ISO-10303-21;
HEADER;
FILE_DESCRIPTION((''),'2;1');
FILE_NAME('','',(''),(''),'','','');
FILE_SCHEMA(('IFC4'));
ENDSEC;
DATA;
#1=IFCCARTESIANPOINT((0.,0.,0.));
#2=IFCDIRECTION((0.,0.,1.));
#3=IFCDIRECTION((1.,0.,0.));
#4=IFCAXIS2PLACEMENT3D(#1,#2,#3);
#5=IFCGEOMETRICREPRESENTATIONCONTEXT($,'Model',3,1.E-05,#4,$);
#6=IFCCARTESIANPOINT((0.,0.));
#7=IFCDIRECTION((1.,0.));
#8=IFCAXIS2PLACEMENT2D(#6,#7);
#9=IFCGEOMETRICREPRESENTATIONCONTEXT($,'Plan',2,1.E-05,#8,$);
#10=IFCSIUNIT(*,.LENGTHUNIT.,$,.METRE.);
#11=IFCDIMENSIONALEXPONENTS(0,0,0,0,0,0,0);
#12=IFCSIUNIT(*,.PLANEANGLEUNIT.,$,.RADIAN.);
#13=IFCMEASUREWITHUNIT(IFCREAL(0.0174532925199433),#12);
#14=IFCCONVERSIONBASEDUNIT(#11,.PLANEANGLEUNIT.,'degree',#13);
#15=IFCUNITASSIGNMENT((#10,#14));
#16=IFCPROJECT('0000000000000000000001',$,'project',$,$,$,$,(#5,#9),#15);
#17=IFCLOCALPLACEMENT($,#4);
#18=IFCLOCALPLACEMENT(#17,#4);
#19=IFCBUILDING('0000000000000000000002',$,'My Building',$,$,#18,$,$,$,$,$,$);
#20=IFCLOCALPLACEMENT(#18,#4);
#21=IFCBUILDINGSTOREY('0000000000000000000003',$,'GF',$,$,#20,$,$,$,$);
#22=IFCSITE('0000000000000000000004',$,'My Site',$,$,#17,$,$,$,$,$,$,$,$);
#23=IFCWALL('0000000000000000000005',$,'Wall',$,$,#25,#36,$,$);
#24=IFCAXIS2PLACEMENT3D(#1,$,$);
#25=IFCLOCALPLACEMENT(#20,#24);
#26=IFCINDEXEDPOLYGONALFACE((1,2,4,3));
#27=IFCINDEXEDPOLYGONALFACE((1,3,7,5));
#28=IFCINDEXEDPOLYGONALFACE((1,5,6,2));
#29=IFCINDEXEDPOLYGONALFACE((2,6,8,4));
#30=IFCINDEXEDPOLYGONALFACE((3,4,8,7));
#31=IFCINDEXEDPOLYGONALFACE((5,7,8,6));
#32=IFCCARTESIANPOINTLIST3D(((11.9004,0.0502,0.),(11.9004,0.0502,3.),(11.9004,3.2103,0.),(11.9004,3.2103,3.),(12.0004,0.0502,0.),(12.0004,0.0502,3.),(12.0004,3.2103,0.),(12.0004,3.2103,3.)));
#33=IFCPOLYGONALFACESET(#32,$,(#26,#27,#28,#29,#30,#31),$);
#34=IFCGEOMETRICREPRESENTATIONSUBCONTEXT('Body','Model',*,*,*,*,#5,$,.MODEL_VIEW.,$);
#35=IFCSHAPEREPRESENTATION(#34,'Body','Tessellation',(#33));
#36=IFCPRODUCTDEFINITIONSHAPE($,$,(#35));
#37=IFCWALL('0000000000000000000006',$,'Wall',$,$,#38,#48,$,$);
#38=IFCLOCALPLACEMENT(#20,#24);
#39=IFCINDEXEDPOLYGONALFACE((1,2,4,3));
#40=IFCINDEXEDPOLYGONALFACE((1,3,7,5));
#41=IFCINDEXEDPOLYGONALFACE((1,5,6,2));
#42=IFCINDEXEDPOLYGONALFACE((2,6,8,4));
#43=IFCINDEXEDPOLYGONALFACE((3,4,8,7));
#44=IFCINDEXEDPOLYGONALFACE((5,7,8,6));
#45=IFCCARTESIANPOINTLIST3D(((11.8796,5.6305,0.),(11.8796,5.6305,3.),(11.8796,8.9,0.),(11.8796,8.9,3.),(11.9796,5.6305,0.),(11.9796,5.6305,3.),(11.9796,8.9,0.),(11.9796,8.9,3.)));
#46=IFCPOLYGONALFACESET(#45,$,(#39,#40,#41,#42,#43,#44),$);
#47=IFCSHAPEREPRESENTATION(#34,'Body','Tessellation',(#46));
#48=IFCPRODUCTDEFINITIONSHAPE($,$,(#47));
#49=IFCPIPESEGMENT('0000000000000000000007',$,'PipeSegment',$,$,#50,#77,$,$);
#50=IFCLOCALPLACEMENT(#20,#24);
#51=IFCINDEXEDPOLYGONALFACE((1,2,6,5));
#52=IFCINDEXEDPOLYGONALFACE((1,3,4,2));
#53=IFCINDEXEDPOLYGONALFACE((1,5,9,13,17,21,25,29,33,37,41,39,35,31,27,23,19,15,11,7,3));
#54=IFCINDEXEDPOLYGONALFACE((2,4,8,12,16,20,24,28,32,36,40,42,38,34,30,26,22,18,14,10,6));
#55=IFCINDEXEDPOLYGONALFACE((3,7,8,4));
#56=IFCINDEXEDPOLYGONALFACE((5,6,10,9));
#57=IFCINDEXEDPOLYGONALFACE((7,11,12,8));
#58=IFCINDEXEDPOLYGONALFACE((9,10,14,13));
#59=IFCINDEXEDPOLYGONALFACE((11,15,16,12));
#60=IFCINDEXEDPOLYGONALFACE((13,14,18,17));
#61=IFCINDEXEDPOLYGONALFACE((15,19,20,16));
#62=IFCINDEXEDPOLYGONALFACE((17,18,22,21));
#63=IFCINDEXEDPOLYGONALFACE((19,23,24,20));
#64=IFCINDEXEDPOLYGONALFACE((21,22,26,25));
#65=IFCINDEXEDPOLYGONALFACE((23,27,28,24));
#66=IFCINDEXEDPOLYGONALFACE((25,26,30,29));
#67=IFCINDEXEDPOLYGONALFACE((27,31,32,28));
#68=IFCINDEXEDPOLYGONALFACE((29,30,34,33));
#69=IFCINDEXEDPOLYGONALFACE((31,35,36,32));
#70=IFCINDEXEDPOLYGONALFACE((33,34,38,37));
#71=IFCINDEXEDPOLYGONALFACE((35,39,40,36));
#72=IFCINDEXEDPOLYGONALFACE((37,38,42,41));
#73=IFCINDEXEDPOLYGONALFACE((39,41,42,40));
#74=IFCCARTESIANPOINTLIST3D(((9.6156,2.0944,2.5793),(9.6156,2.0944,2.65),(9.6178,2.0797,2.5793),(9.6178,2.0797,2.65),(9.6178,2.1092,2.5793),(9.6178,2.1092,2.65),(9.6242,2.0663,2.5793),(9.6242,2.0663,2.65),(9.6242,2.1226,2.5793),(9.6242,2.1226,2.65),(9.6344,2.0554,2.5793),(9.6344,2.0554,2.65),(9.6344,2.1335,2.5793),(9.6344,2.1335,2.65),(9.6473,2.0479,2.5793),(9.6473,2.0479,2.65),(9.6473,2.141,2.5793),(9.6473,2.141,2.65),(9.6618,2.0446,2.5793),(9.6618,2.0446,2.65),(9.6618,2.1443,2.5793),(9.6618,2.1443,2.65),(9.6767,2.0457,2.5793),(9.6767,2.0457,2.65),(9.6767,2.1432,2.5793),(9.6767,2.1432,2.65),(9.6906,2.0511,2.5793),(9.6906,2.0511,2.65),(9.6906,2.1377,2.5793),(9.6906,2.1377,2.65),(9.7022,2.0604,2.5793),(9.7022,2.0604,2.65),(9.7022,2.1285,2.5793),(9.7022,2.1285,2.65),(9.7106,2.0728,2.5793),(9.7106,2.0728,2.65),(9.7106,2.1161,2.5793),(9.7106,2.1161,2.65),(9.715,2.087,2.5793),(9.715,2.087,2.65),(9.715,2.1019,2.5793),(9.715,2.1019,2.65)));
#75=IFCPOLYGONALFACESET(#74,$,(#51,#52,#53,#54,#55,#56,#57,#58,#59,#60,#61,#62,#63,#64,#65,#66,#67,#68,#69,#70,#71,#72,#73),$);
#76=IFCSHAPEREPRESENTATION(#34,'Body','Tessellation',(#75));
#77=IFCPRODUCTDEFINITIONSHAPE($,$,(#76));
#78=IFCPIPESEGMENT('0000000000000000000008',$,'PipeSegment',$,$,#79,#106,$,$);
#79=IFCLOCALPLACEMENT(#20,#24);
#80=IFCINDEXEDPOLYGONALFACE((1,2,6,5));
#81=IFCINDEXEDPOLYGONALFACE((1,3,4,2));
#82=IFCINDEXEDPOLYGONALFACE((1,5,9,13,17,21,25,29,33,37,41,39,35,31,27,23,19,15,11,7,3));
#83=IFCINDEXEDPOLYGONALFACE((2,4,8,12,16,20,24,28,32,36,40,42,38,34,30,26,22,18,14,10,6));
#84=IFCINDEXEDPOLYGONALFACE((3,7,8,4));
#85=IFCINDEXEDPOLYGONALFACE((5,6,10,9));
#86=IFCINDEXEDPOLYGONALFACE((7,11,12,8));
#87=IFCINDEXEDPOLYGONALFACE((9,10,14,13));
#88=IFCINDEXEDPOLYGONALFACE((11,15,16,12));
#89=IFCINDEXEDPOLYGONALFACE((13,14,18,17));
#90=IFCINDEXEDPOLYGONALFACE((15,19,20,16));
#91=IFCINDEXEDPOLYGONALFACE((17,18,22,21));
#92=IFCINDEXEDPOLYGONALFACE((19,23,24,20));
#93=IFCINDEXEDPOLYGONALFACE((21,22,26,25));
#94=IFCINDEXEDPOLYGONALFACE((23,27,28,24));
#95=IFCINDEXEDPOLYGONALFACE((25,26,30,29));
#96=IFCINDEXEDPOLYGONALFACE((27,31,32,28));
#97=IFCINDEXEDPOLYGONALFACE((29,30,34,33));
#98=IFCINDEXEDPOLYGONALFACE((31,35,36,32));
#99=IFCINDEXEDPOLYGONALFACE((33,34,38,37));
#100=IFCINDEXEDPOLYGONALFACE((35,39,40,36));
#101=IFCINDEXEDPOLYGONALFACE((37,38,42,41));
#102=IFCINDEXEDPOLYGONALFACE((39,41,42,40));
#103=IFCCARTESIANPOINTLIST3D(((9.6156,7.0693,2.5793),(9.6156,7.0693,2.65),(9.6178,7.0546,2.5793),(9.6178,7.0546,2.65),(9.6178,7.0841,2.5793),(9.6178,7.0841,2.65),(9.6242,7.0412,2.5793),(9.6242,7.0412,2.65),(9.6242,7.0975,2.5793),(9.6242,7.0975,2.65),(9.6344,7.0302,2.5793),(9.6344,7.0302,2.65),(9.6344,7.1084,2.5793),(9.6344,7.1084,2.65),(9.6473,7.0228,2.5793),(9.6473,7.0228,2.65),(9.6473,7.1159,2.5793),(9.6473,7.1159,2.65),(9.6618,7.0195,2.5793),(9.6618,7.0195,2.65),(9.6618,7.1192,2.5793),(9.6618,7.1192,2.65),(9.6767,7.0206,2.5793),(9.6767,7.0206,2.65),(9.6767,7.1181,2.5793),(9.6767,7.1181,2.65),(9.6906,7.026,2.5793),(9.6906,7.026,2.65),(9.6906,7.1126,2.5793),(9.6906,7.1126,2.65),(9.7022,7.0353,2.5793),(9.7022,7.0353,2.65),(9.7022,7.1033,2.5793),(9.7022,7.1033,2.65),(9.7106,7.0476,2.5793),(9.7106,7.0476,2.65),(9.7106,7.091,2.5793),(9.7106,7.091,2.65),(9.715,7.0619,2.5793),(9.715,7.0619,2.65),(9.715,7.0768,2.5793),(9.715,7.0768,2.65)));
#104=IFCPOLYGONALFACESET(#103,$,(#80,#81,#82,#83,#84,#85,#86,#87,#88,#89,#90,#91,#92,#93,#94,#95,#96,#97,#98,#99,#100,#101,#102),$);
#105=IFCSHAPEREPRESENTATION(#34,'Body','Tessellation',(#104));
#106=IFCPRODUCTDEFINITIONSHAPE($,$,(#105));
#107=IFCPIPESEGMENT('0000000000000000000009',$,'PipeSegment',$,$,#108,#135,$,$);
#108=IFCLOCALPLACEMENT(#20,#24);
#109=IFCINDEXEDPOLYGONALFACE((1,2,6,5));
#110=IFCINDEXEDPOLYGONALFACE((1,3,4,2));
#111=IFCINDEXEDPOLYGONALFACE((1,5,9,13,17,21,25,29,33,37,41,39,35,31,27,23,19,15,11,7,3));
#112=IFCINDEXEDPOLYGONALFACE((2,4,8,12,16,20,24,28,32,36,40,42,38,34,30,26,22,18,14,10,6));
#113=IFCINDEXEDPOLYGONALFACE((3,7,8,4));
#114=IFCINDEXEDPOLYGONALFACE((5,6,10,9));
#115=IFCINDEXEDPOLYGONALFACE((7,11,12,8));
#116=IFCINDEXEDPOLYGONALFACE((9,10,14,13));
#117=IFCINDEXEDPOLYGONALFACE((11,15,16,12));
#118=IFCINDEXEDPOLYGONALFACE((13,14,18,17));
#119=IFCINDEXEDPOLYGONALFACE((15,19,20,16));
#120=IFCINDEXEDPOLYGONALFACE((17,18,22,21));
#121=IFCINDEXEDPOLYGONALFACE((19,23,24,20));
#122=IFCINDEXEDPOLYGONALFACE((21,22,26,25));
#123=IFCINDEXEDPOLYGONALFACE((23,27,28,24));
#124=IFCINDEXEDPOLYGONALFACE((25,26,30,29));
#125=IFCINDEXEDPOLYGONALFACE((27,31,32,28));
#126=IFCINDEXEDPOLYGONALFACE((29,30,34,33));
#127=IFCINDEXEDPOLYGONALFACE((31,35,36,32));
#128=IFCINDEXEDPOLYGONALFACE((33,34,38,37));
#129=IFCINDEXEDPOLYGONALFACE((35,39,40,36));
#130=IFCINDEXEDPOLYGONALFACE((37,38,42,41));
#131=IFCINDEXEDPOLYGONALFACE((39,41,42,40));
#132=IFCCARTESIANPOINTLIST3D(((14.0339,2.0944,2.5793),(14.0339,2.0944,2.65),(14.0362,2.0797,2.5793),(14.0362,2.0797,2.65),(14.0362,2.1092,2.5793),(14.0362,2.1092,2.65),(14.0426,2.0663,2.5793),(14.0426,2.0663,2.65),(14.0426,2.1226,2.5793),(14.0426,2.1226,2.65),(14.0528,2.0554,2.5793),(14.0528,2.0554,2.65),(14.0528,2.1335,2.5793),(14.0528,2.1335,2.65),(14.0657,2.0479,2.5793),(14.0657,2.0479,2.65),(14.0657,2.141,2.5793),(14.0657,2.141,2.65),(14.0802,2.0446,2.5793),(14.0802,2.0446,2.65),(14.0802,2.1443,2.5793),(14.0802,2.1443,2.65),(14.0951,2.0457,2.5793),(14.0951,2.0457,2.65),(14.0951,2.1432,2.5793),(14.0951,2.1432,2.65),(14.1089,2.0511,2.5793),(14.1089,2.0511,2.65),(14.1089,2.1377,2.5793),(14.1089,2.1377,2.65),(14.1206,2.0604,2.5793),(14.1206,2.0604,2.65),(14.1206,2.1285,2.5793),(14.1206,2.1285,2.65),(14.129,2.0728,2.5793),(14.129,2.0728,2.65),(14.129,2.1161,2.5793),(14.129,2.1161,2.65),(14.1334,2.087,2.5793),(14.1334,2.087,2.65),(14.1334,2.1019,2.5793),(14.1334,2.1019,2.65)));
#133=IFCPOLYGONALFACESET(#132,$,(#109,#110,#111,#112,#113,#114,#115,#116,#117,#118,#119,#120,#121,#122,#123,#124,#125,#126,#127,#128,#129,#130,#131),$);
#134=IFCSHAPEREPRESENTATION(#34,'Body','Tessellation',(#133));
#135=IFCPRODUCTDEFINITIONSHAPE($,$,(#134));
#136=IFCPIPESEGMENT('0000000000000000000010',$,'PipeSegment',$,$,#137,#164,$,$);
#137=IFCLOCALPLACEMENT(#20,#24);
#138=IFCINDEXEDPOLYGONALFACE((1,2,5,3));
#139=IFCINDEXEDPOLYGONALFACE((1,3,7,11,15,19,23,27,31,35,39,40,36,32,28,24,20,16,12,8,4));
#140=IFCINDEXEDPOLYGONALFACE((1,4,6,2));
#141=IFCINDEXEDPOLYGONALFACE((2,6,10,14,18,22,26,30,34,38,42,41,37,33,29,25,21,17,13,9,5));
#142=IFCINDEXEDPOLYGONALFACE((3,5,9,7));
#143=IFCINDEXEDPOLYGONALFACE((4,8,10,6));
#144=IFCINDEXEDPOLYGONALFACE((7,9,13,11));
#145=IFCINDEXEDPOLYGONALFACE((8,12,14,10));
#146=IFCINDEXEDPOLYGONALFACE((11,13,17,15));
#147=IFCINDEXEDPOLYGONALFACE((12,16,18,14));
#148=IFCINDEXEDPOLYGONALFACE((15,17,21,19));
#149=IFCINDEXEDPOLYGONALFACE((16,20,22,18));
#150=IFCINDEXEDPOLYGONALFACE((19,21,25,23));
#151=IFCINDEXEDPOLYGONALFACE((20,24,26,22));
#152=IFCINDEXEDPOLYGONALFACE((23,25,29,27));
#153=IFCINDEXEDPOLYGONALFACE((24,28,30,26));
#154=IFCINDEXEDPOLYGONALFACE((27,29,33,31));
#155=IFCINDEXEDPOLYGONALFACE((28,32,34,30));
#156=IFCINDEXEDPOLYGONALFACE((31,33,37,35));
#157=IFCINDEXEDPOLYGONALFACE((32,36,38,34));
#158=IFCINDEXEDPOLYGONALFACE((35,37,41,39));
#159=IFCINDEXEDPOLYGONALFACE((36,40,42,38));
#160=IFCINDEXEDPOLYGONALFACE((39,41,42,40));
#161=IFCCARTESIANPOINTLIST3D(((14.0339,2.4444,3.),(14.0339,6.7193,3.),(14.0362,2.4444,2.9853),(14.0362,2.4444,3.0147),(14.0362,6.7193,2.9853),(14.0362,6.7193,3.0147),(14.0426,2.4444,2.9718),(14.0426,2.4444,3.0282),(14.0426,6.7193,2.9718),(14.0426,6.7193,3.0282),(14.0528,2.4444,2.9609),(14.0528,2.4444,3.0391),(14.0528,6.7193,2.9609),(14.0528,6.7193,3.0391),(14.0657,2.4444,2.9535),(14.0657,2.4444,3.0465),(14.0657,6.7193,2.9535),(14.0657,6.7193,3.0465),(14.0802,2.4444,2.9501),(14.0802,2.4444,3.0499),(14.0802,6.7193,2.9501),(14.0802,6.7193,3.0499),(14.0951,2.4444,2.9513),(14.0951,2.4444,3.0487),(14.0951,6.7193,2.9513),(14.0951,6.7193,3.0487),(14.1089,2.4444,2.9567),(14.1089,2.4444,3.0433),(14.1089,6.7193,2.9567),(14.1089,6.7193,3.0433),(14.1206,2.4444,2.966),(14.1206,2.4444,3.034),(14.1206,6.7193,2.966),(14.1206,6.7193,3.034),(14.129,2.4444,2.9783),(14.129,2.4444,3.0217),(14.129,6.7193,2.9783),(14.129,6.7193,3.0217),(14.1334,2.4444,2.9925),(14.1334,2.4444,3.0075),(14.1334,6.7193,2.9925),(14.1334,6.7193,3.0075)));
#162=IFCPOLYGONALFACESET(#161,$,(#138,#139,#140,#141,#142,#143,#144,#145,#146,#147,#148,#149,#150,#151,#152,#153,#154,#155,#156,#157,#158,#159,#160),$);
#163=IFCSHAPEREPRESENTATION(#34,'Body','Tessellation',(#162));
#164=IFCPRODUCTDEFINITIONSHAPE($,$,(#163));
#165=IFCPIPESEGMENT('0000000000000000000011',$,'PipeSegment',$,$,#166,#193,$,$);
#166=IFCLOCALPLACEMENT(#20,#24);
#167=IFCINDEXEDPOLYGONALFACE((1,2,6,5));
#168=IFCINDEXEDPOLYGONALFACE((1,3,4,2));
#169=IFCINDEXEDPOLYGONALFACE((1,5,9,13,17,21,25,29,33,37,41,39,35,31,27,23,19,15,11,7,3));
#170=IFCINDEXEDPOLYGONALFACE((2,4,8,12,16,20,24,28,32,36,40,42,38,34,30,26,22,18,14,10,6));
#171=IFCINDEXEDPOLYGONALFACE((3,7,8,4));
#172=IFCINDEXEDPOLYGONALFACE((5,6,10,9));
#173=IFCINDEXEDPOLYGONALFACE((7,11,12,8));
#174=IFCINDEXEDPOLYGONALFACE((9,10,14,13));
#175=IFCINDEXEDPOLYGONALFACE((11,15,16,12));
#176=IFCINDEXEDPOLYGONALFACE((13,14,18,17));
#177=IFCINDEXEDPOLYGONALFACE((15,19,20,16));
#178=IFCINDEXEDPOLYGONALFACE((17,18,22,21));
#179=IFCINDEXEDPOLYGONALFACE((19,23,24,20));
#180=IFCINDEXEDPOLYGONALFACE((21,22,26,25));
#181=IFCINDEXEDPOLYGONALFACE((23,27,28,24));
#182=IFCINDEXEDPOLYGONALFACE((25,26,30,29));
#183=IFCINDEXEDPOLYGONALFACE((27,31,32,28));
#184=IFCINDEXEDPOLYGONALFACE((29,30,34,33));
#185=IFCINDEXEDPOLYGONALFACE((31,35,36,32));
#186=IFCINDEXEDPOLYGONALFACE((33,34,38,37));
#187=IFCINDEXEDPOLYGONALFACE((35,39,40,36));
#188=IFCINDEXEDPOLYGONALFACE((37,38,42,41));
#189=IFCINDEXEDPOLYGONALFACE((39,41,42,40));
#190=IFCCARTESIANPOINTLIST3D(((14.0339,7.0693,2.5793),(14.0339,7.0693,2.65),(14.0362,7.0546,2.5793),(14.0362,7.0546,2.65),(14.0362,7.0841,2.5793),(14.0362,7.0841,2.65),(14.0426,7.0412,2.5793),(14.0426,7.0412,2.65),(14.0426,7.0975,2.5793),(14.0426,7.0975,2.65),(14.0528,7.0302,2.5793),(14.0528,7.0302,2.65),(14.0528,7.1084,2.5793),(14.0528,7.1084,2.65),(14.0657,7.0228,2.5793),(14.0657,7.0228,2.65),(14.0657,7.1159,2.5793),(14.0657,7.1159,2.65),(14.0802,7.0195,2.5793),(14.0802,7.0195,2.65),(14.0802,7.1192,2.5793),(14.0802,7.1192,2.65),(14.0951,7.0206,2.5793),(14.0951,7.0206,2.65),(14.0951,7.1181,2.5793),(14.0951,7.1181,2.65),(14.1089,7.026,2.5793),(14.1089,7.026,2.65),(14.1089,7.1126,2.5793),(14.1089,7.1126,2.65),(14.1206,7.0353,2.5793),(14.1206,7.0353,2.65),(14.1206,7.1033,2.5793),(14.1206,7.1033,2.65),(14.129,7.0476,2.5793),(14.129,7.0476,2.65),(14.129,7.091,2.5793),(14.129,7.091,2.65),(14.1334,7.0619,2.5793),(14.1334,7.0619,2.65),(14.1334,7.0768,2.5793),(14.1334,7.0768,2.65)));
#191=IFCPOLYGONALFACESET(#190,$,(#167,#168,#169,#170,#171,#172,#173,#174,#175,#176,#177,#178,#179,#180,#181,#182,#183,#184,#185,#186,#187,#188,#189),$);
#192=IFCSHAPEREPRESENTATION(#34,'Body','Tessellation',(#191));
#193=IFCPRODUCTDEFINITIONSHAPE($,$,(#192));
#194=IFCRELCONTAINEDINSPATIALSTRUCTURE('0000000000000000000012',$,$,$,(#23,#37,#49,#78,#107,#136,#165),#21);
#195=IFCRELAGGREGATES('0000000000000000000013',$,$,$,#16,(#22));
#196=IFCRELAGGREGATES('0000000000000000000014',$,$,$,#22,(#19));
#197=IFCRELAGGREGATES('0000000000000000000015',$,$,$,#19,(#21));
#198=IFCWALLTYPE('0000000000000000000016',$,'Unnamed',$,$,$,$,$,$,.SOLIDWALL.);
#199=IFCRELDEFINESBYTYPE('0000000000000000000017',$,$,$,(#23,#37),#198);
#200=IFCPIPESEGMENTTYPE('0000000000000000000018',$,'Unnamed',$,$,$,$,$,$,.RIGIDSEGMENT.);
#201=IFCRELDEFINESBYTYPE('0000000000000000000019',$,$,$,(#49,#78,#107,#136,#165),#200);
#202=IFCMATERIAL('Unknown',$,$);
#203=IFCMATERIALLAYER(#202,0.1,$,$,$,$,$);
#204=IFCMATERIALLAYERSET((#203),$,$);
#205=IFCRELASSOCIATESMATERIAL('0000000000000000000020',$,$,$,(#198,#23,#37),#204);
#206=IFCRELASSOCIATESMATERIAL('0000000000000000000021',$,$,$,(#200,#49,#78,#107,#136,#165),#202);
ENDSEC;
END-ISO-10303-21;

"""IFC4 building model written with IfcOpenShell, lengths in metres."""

from ifc_helpers import new_model, entity, si_unit, converted_unit, frame, origin_with_axes, origin_2d_with_axis, place, context, subcontext, project, spatial, line, indexed_curve, circle, outline, extrude, material, layer, layer_set, layer_usage, material_profile, profile_set, profile_usage, type_object, element, save


model = new_model("IFC4")

# Units and contexts
model_context = context("Model", 3, precision=1e-05, world=origin_with_axes())
plan_context = context("Plan", 2, precision=1e-05, world=origin_2d_with_axis())
body_context = subcontext(model_context, "Body", "Model", "MODEL_VIEW")
ifc_project = project(units=[si_unit("LENGTHUNIT", "METRE"), converted_unit("PLANEANGLEUNIT", "degree", entity("IfcReal", 0.0174532925199433), si_unit("PLANEANGLEUNIT", "RADIAN"), dimensions=[0, 0, 0, 0, 0, 0, 0])], contexts=[model_context, plan_context])

# Site, building, storey
site_placement = place(None, origin_with_axes())
site = spatial("IfcSite", under=ifc_project, at=site_placement, Name="My Site")
building_placement = place(site_placement, origin_with_axes())
building = spatial("IfcBuilding", under=site, at=building_placement, Name="My Building")
storey_placement = place(building_placement, origin_with_axes())
storey = spatial("IfcBuildingStorey", under=building, at=storey_placement, Name="GF")

# Walls
ifc_material = material(Name="Unknown")
ifc_layer = layer(ifc_material, 0.1)
ifc_layer_set = layer_set([ifc_layer])
ifc_layer_usage_1 = layer_usage(ifc_layer_set, "AXIS2", "POSITIVE", 0.0)
wall_type = type_object("IfcWallType", Name="Unnamed", PredefinedType="SOLIDWALL", material=ifc_layer_set)
wall_1_placement = place(storey_placement, frame((12.0004, 0.0502, 0.0), z_axis=(0.0, 0.0, 1.0), x_axis=(0.000013, 1.0, 0.0)))
element("IfcWall", 1, at=wall_1_placement, inside=storey, type_object=wall_type, material=ifc_layer_usage_1, Name="Wall", context=body_context, shape_type="SweptSolid", body=[
    extrude(outline(indexed_curve([(0.0, 0.0), (0.0, 0.1), (3.1602, 0.1), (3.1602, 0.0)], segments=[line(1, 2, 3, 4, 1)])), origin_with_axes(), (0.0, 0.0, 1.0), 3.0),
])
ifc_layer_usage_2 = layer_usage(ifc_layer_set, "AXIS2", "POSITIVE", 0.0)
wall_2_placement = place(storey_placement, frame((11.9796, 5.6305, 0.0), z_axis=(0.0, 0.0, 1.0), x_axis=(0.0, 1.0, 0.0)))
element("IfcWall", 2, at=wall_2_placement, inside=storey, type_object=wall_type, material=ifc_layer_usage_2, Name="Wall", context=body_context, shape_type="SweptSolid", body=[
    extrude(outline(indexed_curve([(0.0, 0.0), (0.0, 0.1), (3.2695, 0.1), (3.2695, 0.0)], segments=[line(1, 2, 3, 4, 1)])), origin_with_axes(), (0.0, 0.0, 1.0), 3.0),
])

# Pipe segments
ifc_material_profile = material_profile(ifc_material, circle(Radius=0.05))
ifc_profile_set = profile_set([ifc_material_profile])
ifc_profile_usage_1 = profile_usage(ifc_profile_set, cardinal=5)
pipe_segment_type = type_object("IfcPipeSegmentType", Name="Unnamed", PredefinedType="RIGIDSEGMENT", material=ifc_profile_set)
pipe_segment_1_placement = place(storey_placement, frame((9.6656, 2.0944, 2.65), z_axis=(0.0, 0.0, -1.0), x_axis=(-1.0, 0.0, 0.0)))
element("IfcPipeSegment", 3, at=pipe_segment_1_placement, inside=storey, type_object=pipe_segment_type, material=ifc_profile_usage_1, Name="PipeSegment", context=body_context, shape_type="SweptSolid", body=[
    extrude(circle(Radius=0.05), origin_with_axes(), (0.0, 0.0, 1.0), 0.0707),
])
ifc_profile_usage_2 = profile_usage(ifc_profile_set, cardinal=5)
pipe_segment_2_placement = place(storey_placement, frame((9.6656, 7.0693, 2.65), z_axis=(0.0, 0.0, -1.0), x_axis=(-1.0, 0.0, 0.0)))
element("IfcPipeSegment", 4, at=pipe_segment_2_placement, inside=storey, type_object=pipe_segment_type, material=ifc_profile_usage_2, Name="PipeSegment", context=body_context, shape_type="SweptSolid", body=[
    extrude(circle(Radius=0.05), origin_with_axes(), (0.0, 0.0, 1.0), 0.0707),
])
ifc_profile_usage_3 = profile_usage(ifc_profile_set, cardinal=5)
pipe_segment_3_placement = place(storey_placement, frame((14.0839, 2.0944, 2.65), z_axis=(0.0, 0.0, -1.0), x_axis=(-1.0, 0.0, 0.0)))
element("IfcPipeSegment", 5, at=pipe_segment_3_placement, inside=storey, type_object=pipe_segment_type, material=ifc_profile_usage_3, Name="PipeSegment", context=body_context, shape_type="SweptSolid", body=[
    extrude(circle(Radius=0.05), origin_with_axes(), (0.0, 0.0, 1.0), 0.0707),
])
ifc_profile_usage_4 = profile_usage(ifc_profile_set, cardinal=5)
pipe_segment_4_placement = place(storey_placement, frame((14.0839, 2.4444, 3.0), z_axis=(0.0, 1.0, 0.0), x_axis=(-1.0, 0.0, 0.0)))
element("IfcPipeSegment", 6, at=pipe_segment_4_placement, inside=storey, type_object=pipe_segment_type, material=ifc_profile_usage_4, Name="PipeSegment", context=body_context, shape_type="SweptSolid", body=[
    extrude(circle(Radius=0.05), origin_with_axes(), (0.0, 0.0, 1.0), 4.2749),
])
ifc_profile_usage_5 = profile_usage(ifc_profile_set, cardinal=5)
pipe_segment_5_placement = place(storey_placement, frame((14.0839, 7.0693, 2.65), z_axis=(0.0, 0.0, -1.0), x_axis=(-1.0, 0.0, 0.0)))
element("IfcPipeSegment", 7, at=pipe_segment_5_placement, inside=storey, type_object=pipe_segment_type, material=ifc_profile_usage_5, Name="PipeSegment", context=body_context, shape_type="SweptSolid", body=[
    extrude(circle(Radius=0.05), origin_with_axes(), (0.0, 0.0, 1.0), 0.0707),
])

save(model, "model.ifc")
